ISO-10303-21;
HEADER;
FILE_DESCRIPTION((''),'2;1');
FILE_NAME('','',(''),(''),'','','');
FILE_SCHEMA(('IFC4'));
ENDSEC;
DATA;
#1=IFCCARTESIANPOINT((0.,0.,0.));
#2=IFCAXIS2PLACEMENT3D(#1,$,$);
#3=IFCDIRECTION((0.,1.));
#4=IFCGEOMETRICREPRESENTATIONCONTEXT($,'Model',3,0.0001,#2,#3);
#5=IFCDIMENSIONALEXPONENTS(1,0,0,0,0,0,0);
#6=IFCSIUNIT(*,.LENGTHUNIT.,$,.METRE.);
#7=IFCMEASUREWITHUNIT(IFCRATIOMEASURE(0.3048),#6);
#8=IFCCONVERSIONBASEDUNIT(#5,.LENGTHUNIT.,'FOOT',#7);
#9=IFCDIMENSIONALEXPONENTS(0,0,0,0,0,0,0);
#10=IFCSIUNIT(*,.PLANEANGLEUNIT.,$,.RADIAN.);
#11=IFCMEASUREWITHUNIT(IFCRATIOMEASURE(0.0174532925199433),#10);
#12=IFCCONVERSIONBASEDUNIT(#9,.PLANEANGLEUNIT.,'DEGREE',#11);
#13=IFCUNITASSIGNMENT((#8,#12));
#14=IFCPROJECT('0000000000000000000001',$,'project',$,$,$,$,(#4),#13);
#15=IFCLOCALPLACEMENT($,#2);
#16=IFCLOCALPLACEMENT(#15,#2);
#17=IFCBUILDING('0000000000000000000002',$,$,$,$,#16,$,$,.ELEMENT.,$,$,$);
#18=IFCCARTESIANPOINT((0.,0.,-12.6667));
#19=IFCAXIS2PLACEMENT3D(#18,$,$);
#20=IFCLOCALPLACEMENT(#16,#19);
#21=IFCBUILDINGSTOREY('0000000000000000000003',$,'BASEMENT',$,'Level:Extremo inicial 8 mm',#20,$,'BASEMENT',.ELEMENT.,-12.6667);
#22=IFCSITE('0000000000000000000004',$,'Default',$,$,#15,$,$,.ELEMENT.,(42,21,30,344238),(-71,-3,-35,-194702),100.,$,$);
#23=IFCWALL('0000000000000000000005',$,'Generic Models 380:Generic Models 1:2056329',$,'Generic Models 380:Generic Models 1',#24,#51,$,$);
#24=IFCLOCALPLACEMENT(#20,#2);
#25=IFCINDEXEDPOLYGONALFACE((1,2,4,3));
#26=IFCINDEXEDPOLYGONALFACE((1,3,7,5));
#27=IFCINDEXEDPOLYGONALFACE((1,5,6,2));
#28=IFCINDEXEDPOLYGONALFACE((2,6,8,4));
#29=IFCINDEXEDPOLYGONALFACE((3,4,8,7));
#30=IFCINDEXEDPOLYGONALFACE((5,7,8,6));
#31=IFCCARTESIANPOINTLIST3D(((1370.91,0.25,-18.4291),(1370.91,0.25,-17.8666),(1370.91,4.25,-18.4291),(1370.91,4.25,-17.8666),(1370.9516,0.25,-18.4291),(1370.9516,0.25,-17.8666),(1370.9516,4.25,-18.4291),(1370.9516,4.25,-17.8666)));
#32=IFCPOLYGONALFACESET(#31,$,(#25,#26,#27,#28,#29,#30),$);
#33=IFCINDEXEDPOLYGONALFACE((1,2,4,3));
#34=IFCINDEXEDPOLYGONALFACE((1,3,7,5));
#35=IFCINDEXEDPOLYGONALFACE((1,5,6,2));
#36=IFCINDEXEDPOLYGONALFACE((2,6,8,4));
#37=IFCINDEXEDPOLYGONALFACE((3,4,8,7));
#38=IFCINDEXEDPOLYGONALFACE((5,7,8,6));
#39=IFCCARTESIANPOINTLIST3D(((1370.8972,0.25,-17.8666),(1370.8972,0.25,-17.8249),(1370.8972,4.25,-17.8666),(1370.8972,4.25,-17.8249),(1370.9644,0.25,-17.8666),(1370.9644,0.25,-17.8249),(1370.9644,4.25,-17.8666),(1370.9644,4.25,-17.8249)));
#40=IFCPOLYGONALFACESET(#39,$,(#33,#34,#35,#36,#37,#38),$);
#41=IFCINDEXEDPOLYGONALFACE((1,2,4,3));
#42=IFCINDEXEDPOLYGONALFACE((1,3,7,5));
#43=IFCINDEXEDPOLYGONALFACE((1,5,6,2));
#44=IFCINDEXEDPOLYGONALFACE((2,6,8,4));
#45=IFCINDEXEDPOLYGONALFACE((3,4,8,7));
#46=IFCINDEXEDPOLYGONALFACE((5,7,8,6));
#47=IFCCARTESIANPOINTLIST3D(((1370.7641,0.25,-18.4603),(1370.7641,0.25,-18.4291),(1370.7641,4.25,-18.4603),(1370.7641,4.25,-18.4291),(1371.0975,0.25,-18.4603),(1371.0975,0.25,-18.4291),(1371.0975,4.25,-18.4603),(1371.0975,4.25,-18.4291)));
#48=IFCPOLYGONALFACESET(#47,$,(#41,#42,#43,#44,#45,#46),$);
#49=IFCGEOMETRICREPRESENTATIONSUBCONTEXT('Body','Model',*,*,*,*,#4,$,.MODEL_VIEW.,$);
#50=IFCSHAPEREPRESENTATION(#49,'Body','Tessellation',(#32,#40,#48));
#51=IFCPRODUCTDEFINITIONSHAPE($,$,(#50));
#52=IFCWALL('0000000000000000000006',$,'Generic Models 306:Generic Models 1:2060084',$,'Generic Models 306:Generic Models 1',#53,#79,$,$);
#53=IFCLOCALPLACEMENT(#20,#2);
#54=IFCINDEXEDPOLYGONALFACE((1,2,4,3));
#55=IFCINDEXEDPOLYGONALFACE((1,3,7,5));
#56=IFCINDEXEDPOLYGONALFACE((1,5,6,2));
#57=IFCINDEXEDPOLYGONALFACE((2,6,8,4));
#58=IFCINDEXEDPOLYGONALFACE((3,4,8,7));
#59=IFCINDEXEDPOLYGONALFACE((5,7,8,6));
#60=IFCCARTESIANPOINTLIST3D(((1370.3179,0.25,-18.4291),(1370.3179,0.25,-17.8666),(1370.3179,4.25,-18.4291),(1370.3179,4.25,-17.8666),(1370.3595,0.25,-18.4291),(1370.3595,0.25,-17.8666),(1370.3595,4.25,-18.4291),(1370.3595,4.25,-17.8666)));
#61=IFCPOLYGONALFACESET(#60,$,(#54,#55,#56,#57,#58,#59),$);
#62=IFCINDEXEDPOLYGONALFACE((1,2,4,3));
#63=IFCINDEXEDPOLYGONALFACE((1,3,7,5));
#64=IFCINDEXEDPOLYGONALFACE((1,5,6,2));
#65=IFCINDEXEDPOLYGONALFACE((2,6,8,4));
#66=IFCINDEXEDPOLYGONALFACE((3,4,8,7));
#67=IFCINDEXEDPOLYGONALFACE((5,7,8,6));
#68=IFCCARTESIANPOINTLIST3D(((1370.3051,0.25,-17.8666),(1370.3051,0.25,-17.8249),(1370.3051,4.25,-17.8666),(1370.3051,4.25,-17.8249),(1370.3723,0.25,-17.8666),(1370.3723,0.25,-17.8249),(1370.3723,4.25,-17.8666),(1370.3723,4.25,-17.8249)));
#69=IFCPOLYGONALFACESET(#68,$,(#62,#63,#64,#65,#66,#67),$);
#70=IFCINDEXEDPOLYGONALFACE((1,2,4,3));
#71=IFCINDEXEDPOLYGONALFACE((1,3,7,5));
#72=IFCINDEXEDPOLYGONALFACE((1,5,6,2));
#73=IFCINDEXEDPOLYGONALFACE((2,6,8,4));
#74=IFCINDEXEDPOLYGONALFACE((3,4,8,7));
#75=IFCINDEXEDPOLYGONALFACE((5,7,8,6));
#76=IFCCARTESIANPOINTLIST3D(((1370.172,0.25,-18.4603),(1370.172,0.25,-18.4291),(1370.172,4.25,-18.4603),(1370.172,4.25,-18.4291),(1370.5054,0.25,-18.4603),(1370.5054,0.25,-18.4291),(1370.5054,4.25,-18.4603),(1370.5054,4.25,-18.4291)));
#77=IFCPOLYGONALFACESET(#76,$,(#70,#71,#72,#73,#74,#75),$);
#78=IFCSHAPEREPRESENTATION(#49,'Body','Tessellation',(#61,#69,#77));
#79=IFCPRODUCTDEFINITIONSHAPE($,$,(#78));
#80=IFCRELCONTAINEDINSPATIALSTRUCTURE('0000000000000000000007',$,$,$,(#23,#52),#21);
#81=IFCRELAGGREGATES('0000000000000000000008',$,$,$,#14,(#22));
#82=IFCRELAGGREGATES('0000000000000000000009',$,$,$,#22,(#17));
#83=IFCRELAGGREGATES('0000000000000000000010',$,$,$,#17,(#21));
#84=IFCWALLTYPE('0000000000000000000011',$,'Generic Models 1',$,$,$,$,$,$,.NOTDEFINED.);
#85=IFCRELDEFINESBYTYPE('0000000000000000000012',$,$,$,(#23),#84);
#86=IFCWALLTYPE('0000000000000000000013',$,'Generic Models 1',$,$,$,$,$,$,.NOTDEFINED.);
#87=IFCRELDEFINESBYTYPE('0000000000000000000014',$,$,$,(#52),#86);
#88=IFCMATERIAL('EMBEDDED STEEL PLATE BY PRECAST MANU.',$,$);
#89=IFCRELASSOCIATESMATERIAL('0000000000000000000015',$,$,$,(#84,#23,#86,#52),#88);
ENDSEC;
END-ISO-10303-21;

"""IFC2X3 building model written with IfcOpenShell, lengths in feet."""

from ifc_helpers import new_model, entity, si_unit, converted_unit, direction, frame, frame_2d, origin, place, context, subcontext, project, spatial, rectangle, extrude, material, type_object, element, save


model = new_model("IFC2X3")

# Units and contexts
model_context = context("Model", 3, precision=0.0001, world=origin(), true_north=direction((0.0, 1.0)))
body_context = subcontext(model_context, "Body", "Model", "MODEL_VIEW")
ifc_project = project(units=[converted_unit("LENGTHUNIT", "FOOT", entity("IfcRatioMeasure", 0.3048), si_unit("LENGTHUNIT", "METRE"), dimensions=[1, 0, 0, 0, 0, 0, 0]), converted_unit("PLANEANGLEUNIT", "DEGREE", entity("IfcRatioMeasure", 0.0174532925199433), si_unit("PLANEANGLEUNIT", "RADIAN"), dimensions=[0, 0, 0, 0, 0, 0, 0])], contexts=[model_context])

# Site, building, storey
site_placement = place(None, origin())
site = spatial("IfcSite", under=ifc_project, at=site_placement, Name="Default", CompositionType="ELEMENT", RefLatitude=(42, 21, 30, 344238), RefLongitude=(-71, -3, -35, -194702), RefElevation=100.0)
building_placement = place(site_placement, origin())
building = spatial("IfcBuilding", under=site, at=building_placement, CompositionType="ELEMENT")
storey_placement = place(building_placement, frame((0.0, 0.0, -12.6667)))
storey = spatial("IfcBuildingStorey", under=building, at=storey_placement, Name="BASEMENT", ObjectType="Level:Extremo inicial 8 mm", LongName="BASEMENT", CompositionType="ELEMENT", Elevation=-12.6667)

# Walls
ifc_material_1 = material(Name="EMBEDDED STEEL PLATE BY PRECAST MANU.")
wall_type_1 = type_object("IfcWallType", Name="Generic Models 1", PredefinedType="NOTDEFINED", material=ifc_material_1)
wall_1_placement = place(storey_placement, frame((1370.7641, 0.25, -18.4603), z_axis=(0.0, 0.0, 1.0), x_axis=(0.0, 1.0, 0.0)))
element("IfcWall", 1, at=wall_1_placement, inside=storey, type_object=wall_type_1, material=ifc_material_1, Name="Generic Models 380:Generic Models 1:2056329", ObjectType="Generic Models 380:Generic Models 1", context=body_context, shape_type="SweptSolid", body=[
    extrude(rectangle(XDim=4.0, YDim=0.0417, at=frame_2d((0.0, 0.0), x_axis=(1.0, 0.0))), frame((2.0, -0.1667, 0.0312)), (0.0, 0.0, 1.0), 0.5625),
    extrude(rectangle(XDim=4.0, YDim=0.0673, at=frame_2d((0.0, 0.0), x_axis=(1.0, 0.0))), frame((2.0, -0.1667, 0.5937)), (0.0, 0.0, 1.0), 0.0417),
    extrude(rectangle(XDim=4.0, YDim=0.3333, at=frame_2d((0.0, 0.0), x_axis=(1.0, 0.0))), frame((2.0, -0.1667, 0.0)), (0.0, 0.0, 1.0), 0.0312),
])
wall_type_2 = type_object("IfcWallType", Name="Generic Models 1", PredefinedType="NOTDEFINED", material=ifc_material_1)
wall_2_placement = place(storey_placement, frame((1370.172, 0.25, -18.4603), z_axis=(0.0, 0.0, 1.0), x_axis=(0.0, 1.0, 0.0)))
element("IfcWall", 2, at=wall_2_placement, inside=storey, type_object=wall_type_2, material=ifc_material_1, Name="Generic Models 306:Generic Models 1:2060084", ObjectType="Generic Models 306:Generic Models 1", context=body_context, shape_type="SweptSolid", body=[
    extrude(rectangle(XDim=4.0, YDim=0.0417, at=frame_2d((0.0, 0.0), x_axis=(1.0, 0.0))), frame((2.0, -0.1667, 0.0312)), (0.0, 0.0, 1.0), 0.5625),
    extrude(rectangle(XDim=4.0, YDim=0.0673, at=frame_2d((0.0, 0.0), x_axis=(1.0, 0.0))), frame((2.0, -0.1667, 0.5937)), (0.0, 0.0, 1.0), 0.0417),
    extrude(rectangle(XDim=4.0, YDim=0.3333, at=frame_2d((0.0, 0.0), x_axis=(1.0, 0.0))), frame((2.0, -0.1667, 0.0)), (0.0, 0.0, 1.0), 0.0312),
])

save(model, "model.ifc")
